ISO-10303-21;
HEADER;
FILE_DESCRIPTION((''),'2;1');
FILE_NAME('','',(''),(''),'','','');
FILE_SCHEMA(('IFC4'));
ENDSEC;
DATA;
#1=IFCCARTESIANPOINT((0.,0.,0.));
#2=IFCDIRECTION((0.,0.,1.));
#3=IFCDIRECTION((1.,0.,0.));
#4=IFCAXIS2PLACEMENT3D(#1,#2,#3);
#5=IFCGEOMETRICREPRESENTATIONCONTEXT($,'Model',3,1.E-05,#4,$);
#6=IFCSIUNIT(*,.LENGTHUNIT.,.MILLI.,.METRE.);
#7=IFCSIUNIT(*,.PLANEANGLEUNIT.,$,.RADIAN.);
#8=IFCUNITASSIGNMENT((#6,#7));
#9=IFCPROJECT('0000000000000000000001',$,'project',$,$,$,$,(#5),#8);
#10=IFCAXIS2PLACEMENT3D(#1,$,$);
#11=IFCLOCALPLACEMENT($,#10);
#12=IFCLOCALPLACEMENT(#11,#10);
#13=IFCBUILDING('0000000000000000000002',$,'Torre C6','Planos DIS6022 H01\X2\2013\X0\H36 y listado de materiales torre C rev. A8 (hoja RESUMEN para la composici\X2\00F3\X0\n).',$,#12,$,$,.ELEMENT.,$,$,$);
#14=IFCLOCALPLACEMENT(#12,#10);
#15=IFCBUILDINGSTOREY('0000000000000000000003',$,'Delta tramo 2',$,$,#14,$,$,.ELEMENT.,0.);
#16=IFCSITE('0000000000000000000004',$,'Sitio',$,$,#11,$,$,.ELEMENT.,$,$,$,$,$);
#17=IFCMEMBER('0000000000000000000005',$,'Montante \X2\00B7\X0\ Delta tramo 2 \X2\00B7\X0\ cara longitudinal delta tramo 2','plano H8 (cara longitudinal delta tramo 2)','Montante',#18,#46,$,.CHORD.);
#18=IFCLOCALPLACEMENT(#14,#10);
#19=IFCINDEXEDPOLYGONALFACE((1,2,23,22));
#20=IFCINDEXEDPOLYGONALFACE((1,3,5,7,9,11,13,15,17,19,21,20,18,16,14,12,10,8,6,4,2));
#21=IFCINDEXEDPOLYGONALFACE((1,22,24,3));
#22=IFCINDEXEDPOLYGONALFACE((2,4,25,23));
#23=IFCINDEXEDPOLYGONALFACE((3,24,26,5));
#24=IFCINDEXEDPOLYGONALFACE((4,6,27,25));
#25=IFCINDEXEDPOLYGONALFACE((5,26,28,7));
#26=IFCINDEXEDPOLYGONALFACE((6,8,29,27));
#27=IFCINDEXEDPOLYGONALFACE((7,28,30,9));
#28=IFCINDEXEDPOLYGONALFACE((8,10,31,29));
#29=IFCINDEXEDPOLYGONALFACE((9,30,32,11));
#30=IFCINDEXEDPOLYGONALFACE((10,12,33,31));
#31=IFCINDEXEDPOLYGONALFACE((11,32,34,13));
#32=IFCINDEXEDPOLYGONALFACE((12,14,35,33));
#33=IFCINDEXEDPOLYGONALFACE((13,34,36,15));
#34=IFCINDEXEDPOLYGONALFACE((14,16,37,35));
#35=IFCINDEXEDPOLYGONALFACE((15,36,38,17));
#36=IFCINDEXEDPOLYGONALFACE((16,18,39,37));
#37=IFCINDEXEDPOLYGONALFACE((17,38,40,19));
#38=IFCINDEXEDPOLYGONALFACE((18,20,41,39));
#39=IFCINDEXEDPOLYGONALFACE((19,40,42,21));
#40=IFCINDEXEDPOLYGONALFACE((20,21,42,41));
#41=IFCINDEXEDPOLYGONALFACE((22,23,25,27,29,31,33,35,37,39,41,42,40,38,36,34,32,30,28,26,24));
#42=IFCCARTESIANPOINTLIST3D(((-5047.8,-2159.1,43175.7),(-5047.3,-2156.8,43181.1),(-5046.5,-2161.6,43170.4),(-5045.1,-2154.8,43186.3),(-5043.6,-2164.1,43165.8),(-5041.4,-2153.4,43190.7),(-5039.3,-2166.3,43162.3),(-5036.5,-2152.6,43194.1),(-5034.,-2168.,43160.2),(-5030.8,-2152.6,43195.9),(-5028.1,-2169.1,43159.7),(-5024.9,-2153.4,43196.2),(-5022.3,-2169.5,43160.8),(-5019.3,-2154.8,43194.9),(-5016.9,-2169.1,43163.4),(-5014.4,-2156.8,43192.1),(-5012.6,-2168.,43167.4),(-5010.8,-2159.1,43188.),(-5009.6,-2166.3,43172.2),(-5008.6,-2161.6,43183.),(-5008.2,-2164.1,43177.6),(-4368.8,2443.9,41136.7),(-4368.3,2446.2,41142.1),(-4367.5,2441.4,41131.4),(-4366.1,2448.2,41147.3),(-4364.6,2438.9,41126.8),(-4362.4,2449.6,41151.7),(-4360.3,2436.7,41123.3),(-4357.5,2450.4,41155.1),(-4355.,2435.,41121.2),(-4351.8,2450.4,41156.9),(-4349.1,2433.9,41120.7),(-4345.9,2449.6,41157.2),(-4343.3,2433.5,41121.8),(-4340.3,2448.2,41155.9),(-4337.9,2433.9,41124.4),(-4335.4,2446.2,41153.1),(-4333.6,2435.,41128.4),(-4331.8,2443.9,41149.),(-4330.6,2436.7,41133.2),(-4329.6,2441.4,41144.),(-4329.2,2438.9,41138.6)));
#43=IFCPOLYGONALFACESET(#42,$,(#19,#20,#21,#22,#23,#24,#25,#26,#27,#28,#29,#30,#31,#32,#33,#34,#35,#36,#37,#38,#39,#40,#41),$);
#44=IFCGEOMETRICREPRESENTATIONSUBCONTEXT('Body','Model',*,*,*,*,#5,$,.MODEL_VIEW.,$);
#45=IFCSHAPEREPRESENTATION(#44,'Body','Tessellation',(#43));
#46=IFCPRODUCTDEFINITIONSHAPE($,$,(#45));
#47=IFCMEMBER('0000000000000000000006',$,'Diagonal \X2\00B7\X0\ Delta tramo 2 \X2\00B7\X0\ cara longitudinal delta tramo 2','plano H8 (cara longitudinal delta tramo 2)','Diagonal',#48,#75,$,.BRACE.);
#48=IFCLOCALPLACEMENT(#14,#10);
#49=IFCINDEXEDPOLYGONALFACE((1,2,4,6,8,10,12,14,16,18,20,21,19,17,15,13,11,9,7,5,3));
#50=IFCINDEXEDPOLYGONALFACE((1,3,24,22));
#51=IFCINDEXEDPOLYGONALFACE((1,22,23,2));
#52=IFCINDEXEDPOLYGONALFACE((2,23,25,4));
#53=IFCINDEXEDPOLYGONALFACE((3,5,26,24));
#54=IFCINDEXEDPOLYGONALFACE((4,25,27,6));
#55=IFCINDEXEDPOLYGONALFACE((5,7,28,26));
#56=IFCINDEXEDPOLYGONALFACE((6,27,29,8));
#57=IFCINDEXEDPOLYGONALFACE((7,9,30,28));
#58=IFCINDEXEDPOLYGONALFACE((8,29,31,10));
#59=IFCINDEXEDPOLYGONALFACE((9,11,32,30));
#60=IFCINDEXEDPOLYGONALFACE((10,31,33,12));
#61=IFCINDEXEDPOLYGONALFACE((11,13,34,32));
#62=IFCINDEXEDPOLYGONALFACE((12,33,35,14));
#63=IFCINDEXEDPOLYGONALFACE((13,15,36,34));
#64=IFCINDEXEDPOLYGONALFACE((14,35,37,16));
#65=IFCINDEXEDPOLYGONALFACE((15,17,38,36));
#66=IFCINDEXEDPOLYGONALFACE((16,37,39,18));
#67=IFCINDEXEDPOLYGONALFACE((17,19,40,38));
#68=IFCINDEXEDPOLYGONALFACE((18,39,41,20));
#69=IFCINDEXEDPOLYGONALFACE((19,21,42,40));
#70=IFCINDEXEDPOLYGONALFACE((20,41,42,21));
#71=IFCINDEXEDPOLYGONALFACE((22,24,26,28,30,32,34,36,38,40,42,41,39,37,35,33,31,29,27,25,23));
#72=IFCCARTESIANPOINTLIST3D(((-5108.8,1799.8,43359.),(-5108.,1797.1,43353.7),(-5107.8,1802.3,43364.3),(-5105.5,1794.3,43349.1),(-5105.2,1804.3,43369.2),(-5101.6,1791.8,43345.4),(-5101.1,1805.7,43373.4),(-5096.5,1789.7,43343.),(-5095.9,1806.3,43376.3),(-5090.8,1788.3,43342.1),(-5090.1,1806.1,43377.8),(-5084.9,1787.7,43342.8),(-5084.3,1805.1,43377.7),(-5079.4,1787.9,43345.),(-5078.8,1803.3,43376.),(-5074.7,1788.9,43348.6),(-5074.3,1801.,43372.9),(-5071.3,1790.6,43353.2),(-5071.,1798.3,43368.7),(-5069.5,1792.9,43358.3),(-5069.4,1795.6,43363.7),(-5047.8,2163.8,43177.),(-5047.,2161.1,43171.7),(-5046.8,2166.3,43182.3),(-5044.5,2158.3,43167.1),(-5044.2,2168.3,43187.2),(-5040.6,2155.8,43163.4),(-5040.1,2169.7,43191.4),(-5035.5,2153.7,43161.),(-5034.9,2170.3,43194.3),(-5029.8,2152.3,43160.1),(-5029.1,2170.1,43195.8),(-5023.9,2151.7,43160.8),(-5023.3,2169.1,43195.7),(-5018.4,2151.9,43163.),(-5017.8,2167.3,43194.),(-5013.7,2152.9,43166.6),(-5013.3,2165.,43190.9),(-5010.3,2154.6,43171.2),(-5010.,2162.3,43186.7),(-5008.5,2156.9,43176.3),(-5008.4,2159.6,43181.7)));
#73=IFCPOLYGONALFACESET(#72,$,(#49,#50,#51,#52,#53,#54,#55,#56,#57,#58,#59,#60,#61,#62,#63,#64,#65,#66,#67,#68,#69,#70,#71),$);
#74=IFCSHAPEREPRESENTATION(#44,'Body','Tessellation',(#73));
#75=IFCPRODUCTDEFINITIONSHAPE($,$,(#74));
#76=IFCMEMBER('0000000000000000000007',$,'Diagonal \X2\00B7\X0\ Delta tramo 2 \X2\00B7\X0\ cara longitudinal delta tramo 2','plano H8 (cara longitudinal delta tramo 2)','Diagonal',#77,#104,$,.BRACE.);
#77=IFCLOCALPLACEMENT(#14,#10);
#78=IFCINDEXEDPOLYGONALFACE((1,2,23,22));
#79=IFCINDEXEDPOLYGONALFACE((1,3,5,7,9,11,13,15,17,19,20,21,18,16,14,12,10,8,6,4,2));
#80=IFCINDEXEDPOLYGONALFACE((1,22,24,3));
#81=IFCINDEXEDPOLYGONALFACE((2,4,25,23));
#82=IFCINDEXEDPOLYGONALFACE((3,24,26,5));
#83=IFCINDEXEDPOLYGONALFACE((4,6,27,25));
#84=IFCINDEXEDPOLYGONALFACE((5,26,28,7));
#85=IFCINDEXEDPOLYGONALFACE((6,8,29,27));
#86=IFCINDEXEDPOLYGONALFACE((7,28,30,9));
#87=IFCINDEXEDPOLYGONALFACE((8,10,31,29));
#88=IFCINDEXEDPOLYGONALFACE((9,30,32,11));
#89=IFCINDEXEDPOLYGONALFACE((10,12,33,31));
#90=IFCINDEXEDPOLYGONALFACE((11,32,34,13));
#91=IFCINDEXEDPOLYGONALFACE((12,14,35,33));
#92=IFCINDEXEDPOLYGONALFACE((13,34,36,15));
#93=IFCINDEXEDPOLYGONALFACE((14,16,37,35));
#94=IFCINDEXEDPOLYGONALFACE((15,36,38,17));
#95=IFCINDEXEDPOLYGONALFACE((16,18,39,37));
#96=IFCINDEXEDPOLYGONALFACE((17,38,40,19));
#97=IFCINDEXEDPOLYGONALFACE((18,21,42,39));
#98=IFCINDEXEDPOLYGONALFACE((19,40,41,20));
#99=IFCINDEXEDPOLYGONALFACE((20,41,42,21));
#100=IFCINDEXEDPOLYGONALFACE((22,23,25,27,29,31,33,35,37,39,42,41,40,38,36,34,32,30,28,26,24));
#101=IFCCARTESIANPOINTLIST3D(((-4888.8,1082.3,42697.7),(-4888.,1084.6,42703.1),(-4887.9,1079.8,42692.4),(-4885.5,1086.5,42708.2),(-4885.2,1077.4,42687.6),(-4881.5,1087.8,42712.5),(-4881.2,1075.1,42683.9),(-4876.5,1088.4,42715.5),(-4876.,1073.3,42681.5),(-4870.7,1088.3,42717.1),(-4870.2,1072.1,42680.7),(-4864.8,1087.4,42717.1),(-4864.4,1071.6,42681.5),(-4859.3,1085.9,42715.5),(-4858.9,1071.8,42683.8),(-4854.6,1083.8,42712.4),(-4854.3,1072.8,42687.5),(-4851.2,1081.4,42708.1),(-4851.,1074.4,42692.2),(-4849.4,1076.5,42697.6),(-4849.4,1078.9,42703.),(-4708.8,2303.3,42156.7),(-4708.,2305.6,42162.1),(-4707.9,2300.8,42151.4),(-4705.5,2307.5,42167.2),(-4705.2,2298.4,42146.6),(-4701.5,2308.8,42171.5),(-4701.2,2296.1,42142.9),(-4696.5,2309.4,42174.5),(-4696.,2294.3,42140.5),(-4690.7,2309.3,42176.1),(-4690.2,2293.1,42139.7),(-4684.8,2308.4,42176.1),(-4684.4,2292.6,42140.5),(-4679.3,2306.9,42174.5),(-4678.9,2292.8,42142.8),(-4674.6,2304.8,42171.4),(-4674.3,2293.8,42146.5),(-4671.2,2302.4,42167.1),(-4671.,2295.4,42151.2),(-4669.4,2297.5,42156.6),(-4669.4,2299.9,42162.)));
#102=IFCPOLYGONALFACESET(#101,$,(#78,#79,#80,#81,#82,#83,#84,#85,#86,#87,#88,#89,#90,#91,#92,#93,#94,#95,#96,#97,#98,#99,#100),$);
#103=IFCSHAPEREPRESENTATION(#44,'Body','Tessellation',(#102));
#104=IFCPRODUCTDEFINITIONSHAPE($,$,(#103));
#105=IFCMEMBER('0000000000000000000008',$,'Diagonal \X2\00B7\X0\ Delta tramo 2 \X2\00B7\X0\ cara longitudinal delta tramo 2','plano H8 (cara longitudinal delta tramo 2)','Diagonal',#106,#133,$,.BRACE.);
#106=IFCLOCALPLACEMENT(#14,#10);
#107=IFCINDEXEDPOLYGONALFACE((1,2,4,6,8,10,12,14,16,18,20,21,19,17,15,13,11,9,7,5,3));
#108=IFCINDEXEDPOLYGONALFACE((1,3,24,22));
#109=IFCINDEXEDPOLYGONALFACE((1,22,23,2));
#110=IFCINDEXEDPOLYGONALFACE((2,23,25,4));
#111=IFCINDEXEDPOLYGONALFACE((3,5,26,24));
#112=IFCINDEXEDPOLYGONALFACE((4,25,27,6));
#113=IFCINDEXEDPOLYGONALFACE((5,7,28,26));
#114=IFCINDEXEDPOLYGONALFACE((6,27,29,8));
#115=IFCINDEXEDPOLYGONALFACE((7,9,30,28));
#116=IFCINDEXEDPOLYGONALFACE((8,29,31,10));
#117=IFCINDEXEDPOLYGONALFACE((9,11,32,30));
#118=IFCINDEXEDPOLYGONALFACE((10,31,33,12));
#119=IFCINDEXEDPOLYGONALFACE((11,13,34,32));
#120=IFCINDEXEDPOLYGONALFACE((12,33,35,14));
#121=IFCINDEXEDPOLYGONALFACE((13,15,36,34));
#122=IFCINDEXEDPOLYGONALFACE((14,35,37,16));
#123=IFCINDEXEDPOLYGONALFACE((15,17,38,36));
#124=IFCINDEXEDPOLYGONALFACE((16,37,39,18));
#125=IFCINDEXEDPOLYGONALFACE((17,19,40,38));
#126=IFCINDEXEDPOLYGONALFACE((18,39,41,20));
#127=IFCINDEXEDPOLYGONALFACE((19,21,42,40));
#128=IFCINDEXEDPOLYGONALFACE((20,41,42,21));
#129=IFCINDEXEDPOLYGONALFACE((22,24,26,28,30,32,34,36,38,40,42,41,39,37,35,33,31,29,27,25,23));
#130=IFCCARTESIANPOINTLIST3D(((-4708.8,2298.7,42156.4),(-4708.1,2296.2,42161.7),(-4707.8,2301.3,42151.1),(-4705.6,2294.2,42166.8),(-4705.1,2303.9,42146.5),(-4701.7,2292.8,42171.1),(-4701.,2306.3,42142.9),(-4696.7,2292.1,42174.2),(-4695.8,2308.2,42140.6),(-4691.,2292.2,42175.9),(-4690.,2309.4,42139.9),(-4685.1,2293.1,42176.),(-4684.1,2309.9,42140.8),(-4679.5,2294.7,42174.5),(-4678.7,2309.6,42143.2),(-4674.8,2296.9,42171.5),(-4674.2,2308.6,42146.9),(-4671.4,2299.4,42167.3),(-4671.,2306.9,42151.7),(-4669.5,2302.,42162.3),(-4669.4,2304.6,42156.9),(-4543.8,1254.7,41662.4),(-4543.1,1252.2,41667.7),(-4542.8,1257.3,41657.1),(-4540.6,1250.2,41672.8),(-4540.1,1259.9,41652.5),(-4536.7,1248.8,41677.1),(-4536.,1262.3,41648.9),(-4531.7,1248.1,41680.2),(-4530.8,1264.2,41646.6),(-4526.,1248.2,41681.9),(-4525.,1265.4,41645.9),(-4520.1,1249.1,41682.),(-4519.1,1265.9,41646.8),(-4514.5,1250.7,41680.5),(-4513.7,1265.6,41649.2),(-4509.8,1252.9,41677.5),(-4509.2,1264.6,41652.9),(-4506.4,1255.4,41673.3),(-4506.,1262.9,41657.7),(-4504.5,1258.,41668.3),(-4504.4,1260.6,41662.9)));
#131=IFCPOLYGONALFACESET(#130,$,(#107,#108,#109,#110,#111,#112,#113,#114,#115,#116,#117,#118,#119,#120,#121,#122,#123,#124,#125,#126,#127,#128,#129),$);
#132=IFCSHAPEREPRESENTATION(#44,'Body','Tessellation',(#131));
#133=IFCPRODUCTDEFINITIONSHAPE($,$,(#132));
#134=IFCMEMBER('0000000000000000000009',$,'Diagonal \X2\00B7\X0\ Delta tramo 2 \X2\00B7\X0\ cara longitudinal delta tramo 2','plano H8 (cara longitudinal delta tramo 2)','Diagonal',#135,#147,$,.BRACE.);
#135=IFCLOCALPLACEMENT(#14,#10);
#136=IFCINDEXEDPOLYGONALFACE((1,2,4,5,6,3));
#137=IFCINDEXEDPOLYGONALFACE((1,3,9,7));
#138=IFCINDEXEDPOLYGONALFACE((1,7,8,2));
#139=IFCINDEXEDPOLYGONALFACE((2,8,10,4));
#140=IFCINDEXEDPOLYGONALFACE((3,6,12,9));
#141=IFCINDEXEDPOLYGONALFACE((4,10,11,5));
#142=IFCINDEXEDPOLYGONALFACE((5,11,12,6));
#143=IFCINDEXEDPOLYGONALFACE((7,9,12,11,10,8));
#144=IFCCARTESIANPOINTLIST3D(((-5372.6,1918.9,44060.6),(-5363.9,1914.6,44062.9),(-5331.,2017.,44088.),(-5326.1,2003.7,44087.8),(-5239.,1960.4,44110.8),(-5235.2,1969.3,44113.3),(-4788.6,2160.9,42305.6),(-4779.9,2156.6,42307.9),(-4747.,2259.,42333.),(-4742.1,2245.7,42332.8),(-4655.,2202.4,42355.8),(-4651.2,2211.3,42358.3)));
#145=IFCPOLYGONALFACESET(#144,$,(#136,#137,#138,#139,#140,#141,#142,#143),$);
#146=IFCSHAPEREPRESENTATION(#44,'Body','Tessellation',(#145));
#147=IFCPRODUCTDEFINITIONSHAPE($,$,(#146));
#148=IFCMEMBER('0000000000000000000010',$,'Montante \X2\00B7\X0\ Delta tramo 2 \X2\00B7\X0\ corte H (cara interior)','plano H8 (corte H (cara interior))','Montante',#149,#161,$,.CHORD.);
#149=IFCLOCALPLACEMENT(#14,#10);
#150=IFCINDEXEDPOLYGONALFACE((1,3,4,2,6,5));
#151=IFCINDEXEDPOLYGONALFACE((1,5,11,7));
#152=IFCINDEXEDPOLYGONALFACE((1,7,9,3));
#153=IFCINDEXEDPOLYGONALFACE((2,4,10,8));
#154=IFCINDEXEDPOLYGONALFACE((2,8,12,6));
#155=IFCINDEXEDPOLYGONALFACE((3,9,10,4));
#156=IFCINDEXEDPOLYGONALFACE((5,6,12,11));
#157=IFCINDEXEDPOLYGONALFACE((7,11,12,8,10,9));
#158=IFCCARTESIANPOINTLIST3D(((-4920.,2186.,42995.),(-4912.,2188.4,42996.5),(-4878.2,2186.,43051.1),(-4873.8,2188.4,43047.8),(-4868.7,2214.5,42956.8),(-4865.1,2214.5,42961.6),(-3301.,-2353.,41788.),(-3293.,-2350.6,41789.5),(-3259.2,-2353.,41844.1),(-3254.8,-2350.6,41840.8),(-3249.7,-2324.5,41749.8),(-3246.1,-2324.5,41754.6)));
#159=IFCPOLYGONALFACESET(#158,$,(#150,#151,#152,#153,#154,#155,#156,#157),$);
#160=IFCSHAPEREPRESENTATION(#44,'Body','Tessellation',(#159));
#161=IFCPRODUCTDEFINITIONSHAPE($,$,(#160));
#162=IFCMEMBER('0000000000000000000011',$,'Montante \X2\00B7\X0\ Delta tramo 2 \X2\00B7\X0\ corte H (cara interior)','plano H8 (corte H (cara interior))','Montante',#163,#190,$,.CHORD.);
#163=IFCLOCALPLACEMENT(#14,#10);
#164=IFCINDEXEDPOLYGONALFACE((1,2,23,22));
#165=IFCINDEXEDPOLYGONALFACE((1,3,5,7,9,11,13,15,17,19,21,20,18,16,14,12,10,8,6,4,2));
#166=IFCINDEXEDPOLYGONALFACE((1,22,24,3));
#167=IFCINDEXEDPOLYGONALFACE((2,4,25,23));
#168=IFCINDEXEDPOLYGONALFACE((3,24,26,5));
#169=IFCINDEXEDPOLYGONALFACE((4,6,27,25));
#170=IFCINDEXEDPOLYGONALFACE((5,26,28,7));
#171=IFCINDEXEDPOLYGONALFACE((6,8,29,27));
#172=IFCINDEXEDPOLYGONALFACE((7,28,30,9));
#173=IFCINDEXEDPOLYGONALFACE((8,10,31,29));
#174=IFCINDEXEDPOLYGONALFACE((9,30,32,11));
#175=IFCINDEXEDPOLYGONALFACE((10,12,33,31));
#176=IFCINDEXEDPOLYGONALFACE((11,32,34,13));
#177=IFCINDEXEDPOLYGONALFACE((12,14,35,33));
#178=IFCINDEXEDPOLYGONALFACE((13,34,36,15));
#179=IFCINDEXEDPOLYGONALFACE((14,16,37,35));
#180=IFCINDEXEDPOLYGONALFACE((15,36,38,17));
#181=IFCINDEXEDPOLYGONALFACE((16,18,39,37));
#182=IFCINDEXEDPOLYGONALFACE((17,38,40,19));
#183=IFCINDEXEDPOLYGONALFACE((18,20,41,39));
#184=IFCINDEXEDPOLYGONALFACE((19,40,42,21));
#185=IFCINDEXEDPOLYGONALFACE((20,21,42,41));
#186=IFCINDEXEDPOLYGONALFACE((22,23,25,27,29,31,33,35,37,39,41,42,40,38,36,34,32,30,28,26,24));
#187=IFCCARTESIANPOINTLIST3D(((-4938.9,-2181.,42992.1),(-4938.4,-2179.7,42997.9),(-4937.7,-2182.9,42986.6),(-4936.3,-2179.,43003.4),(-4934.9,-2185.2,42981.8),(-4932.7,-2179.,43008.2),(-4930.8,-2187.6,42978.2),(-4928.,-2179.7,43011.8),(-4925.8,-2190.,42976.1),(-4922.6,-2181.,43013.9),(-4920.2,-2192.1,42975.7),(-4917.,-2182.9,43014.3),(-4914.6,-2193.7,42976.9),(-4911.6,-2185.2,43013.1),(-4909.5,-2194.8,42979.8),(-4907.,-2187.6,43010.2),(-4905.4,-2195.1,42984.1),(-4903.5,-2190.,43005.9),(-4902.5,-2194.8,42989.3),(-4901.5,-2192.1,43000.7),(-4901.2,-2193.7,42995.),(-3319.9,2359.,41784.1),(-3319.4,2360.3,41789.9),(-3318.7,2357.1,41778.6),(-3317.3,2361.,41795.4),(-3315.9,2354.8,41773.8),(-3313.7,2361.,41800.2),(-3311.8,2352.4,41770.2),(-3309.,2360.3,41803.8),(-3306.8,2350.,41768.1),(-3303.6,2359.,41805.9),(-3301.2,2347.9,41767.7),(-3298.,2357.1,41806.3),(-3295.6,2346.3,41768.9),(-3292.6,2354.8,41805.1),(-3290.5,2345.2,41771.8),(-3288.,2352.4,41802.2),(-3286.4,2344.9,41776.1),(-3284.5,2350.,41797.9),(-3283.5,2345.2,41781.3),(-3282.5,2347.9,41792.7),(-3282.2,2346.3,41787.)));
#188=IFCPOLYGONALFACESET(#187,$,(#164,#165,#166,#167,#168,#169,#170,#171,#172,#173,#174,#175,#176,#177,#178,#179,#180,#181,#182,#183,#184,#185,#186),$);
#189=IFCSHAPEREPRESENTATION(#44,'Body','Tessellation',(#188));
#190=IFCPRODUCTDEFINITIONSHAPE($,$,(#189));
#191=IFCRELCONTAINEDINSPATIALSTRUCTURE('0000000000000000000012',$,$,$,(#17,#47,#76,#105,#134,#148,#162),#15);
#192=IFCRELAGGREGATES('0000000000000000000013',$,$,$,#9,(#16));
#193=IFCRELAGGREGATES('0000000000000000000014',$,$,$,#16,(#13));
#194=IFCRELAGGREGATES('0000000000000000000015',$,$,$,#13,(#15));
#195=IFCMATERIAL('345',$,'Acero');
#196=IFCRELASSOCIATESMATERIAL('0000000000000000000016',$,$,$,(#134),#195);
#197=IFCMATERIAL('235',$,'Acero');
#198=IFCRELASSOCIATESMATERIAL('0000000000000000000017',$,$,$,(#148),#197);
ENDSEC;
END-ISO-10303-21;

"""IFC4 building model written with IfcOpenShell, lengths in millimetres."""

from ifc_helpers import new_model, si_unit, frame, frame_2d, origin, origin_with_axes, place, context, subcontext, project, spatial, circle, l_section, extrude, material, element, save


model = new_model("IFC4")

# Units and contexts
model_context = context("Model", 3, precision=1e-05, world=origin_with_axes())
body_context = subcontext(model_context, "Body", "Model", "MODEL_VIEW")
ifc_project = project(units=[si_unit("LENGTHUNIT", "METRE", prefix="MILLI"), si_unit("PLANEANGLEUNIT", "RADIAN")], contexts=[model_context])

# Site, building, storey
site_placement = place(None, origin())
site = spatial("IfcSite", under=ifc_project, at=site_placement, Name="Sitio", CompositionType="ELEMENT")
building_placement = place(site_placement, origin())
building = spatial("IfcBuilding", under=site, at=building_placement, Name="Torre C6", Description="Planos DIS6022 H01–H36 y listado de materiales torre C rev. A8 (hoja RESUMEN para la composición).", CompositionType="ELEMENT")
storey_placement = place(building_placement, origin())
storey = spatial("IfcBuildingStorey", under=building, at=storey_placement, Name="Delta tramo 2", CompositionType="ELEMENT", Elevation=0.0)

# Members
ifc_material_1 = material(Name="345", Category="Acero")
member_1_placement = place(storey_placement, frame((-4349.0, 2442.0, 41139.0), z_axis=(-0.133662, -0.906106, 0.40138), x_axis=(0.286283, -0.42305, -0.859692)))
element("IfcMember", 1, at=member_1_placement, inside=storey, Name="Montante · Delta tramo 2 · cara longitudinal delta tramo 2", Description="plano H8 (cara longitudinal delta tramo 2)", ObjectType="Montante", PredefinedType="CHORD", context=body_context, shape_type="SweptSolid", body=[
    extrude(circle(Radius=20.0), None, (0.0, 0.0, 1.0), 5080.0),
])
member_2_placement = place(storey_placement, frame((-5028.0, 2161.0, 43178.0), z_axis=(-0.148234, -0.884546, 0.442273), x_axis=(0.975269, -0.204886, -0.082896)))
element("IfcMember", 2, at=member_2_placement, inside=storey, Name="Diagonal · Delta tramo 2 · cara longitudinal delta tramo 2", Description="plano H8 (cara longitudinal delta tramo 2)", ObjectType="Diagonal", PredefinedType="BRACE", context=body_context, shape_type="SweptSolid", body=[
    extrude(circle(Radius=20.0), None, (0.0, 0.0, 1.0), 411.5),
])
member_3_placement = place(storey_placement, frame((-4689.0, 2301.0, 42158.0), z_axis=(-0.133575, -0.906081, 0.401466), x_axis=(0.981661, -0.176564, -0.071878)))
element("IfcMember", 3, at=member_3_placement, inside=storey, Name="Diagonal · Delta tramo 2 · cara longitudinal delta tramo 2", Description="plano H8 (cara longitudinal delta tramo 2)", ObjectType="Diagonal", PredefinedType="BRACE", context=body_context, shape_type="SweptSolid", body=[
    extrude(circle(Radius=20.0), None, (0.0, 0.0, 1.0), 1347.6),
])
member_4_placement = place(storey_placement, frame((-4524.0, 1257.0, 41664.0), z_axis=(-0.141424, 0.894829, 0.423415), x_axis=(0.975028, 0.051927, 0.215926)))
element("IfcMember", 4, at=member_4_placement, inside=storey, Name="Diagonal · Delta tramo 2 · cara longitudinal delta tramo 2", Description="plano H8 (cara longitudinal delta tramo 2)", ObjectType="Diagonal", PredefinedType="BRACE", context=body_context, shape_type="SweptSolid", body=[
    extrude(circle(Radius=20.0), None, (0.0, 0.0, 1.0), 1166.7),
])
member_5_placement = place(storey_placement, frame((-5331.0, 2017.0, 44088.0), z_axis=(0.313073, 0.129732, -0.940827), x_axis=(0.871133, -0.433819, 0.230061)))
element("IfcMember", 5, at=member_5_placement, inside=storey, material=ifc_material_1, Name="Diagonal · Delta tramo 2 · cara longitudinal delta tramo 2", Description="plano H8 (cara longitudinal delta tramo 2)", ObjectType="Diagonal", PredefinedType="BRACE", context=body_context, shape_type="SweptSolid", body=[
    extrude(l_section(Depth=110.0, Width=110.0, Thickness=10.0, at=frame_2d((55.0, 55.0))), None, (0.0, 0.0, 1.0), 1865.4),
])
ifc_material_2 = material(Name="235", Category="Acero")
member_6_placement = place(storey_placement, frame((-4920.0, 2186.0, 42995.0), z_axis=(0.325889, -0.913656, -0.242957), x_axis=(0.732497, 0.406487, -0.546092)))
element("IfcMember", 6, at=member_6_placement, inside=storey, material=ifc_material_2, Name="Montante · Delta tramo 2 · corte H (cara interior)", Description="plano H8 (corte H (cara interior))", ObjectType="Montante", PredefinedType="CHORD", context=body_context, shape_type="SweptSolid", body=[
    extrude(l_section(Depth=70.0, Width=70.0, Thickness=6.0, at=frame_2d((35.0, 35.0))), None, (0.0, 0.0, 1.0), 4968.0),
])
member_7_placement = place(storey_placement, frame((-3301.0, 2353.0, 41787.0), z_axis=(-0.325813, -0.913645, 0.243102), x_axis=(0.732271, -0.406513, -0.546376)))
element("IfcMember", 7, at=member_7_placement, inside=storey, Name="Montante · Delta tramo 2 · corte H (cara interior)", Description="plano H8 (corte H (cara interior))", ObjectType="Montante", PredefinedType="CHORD", context=body_context, shape_type="SweptSolid", body=[
    extrude(circle(Radius=20.0), None, (0.0, 0.0, 1.0), 4969.1),
])

save(model, "model.ifc")
